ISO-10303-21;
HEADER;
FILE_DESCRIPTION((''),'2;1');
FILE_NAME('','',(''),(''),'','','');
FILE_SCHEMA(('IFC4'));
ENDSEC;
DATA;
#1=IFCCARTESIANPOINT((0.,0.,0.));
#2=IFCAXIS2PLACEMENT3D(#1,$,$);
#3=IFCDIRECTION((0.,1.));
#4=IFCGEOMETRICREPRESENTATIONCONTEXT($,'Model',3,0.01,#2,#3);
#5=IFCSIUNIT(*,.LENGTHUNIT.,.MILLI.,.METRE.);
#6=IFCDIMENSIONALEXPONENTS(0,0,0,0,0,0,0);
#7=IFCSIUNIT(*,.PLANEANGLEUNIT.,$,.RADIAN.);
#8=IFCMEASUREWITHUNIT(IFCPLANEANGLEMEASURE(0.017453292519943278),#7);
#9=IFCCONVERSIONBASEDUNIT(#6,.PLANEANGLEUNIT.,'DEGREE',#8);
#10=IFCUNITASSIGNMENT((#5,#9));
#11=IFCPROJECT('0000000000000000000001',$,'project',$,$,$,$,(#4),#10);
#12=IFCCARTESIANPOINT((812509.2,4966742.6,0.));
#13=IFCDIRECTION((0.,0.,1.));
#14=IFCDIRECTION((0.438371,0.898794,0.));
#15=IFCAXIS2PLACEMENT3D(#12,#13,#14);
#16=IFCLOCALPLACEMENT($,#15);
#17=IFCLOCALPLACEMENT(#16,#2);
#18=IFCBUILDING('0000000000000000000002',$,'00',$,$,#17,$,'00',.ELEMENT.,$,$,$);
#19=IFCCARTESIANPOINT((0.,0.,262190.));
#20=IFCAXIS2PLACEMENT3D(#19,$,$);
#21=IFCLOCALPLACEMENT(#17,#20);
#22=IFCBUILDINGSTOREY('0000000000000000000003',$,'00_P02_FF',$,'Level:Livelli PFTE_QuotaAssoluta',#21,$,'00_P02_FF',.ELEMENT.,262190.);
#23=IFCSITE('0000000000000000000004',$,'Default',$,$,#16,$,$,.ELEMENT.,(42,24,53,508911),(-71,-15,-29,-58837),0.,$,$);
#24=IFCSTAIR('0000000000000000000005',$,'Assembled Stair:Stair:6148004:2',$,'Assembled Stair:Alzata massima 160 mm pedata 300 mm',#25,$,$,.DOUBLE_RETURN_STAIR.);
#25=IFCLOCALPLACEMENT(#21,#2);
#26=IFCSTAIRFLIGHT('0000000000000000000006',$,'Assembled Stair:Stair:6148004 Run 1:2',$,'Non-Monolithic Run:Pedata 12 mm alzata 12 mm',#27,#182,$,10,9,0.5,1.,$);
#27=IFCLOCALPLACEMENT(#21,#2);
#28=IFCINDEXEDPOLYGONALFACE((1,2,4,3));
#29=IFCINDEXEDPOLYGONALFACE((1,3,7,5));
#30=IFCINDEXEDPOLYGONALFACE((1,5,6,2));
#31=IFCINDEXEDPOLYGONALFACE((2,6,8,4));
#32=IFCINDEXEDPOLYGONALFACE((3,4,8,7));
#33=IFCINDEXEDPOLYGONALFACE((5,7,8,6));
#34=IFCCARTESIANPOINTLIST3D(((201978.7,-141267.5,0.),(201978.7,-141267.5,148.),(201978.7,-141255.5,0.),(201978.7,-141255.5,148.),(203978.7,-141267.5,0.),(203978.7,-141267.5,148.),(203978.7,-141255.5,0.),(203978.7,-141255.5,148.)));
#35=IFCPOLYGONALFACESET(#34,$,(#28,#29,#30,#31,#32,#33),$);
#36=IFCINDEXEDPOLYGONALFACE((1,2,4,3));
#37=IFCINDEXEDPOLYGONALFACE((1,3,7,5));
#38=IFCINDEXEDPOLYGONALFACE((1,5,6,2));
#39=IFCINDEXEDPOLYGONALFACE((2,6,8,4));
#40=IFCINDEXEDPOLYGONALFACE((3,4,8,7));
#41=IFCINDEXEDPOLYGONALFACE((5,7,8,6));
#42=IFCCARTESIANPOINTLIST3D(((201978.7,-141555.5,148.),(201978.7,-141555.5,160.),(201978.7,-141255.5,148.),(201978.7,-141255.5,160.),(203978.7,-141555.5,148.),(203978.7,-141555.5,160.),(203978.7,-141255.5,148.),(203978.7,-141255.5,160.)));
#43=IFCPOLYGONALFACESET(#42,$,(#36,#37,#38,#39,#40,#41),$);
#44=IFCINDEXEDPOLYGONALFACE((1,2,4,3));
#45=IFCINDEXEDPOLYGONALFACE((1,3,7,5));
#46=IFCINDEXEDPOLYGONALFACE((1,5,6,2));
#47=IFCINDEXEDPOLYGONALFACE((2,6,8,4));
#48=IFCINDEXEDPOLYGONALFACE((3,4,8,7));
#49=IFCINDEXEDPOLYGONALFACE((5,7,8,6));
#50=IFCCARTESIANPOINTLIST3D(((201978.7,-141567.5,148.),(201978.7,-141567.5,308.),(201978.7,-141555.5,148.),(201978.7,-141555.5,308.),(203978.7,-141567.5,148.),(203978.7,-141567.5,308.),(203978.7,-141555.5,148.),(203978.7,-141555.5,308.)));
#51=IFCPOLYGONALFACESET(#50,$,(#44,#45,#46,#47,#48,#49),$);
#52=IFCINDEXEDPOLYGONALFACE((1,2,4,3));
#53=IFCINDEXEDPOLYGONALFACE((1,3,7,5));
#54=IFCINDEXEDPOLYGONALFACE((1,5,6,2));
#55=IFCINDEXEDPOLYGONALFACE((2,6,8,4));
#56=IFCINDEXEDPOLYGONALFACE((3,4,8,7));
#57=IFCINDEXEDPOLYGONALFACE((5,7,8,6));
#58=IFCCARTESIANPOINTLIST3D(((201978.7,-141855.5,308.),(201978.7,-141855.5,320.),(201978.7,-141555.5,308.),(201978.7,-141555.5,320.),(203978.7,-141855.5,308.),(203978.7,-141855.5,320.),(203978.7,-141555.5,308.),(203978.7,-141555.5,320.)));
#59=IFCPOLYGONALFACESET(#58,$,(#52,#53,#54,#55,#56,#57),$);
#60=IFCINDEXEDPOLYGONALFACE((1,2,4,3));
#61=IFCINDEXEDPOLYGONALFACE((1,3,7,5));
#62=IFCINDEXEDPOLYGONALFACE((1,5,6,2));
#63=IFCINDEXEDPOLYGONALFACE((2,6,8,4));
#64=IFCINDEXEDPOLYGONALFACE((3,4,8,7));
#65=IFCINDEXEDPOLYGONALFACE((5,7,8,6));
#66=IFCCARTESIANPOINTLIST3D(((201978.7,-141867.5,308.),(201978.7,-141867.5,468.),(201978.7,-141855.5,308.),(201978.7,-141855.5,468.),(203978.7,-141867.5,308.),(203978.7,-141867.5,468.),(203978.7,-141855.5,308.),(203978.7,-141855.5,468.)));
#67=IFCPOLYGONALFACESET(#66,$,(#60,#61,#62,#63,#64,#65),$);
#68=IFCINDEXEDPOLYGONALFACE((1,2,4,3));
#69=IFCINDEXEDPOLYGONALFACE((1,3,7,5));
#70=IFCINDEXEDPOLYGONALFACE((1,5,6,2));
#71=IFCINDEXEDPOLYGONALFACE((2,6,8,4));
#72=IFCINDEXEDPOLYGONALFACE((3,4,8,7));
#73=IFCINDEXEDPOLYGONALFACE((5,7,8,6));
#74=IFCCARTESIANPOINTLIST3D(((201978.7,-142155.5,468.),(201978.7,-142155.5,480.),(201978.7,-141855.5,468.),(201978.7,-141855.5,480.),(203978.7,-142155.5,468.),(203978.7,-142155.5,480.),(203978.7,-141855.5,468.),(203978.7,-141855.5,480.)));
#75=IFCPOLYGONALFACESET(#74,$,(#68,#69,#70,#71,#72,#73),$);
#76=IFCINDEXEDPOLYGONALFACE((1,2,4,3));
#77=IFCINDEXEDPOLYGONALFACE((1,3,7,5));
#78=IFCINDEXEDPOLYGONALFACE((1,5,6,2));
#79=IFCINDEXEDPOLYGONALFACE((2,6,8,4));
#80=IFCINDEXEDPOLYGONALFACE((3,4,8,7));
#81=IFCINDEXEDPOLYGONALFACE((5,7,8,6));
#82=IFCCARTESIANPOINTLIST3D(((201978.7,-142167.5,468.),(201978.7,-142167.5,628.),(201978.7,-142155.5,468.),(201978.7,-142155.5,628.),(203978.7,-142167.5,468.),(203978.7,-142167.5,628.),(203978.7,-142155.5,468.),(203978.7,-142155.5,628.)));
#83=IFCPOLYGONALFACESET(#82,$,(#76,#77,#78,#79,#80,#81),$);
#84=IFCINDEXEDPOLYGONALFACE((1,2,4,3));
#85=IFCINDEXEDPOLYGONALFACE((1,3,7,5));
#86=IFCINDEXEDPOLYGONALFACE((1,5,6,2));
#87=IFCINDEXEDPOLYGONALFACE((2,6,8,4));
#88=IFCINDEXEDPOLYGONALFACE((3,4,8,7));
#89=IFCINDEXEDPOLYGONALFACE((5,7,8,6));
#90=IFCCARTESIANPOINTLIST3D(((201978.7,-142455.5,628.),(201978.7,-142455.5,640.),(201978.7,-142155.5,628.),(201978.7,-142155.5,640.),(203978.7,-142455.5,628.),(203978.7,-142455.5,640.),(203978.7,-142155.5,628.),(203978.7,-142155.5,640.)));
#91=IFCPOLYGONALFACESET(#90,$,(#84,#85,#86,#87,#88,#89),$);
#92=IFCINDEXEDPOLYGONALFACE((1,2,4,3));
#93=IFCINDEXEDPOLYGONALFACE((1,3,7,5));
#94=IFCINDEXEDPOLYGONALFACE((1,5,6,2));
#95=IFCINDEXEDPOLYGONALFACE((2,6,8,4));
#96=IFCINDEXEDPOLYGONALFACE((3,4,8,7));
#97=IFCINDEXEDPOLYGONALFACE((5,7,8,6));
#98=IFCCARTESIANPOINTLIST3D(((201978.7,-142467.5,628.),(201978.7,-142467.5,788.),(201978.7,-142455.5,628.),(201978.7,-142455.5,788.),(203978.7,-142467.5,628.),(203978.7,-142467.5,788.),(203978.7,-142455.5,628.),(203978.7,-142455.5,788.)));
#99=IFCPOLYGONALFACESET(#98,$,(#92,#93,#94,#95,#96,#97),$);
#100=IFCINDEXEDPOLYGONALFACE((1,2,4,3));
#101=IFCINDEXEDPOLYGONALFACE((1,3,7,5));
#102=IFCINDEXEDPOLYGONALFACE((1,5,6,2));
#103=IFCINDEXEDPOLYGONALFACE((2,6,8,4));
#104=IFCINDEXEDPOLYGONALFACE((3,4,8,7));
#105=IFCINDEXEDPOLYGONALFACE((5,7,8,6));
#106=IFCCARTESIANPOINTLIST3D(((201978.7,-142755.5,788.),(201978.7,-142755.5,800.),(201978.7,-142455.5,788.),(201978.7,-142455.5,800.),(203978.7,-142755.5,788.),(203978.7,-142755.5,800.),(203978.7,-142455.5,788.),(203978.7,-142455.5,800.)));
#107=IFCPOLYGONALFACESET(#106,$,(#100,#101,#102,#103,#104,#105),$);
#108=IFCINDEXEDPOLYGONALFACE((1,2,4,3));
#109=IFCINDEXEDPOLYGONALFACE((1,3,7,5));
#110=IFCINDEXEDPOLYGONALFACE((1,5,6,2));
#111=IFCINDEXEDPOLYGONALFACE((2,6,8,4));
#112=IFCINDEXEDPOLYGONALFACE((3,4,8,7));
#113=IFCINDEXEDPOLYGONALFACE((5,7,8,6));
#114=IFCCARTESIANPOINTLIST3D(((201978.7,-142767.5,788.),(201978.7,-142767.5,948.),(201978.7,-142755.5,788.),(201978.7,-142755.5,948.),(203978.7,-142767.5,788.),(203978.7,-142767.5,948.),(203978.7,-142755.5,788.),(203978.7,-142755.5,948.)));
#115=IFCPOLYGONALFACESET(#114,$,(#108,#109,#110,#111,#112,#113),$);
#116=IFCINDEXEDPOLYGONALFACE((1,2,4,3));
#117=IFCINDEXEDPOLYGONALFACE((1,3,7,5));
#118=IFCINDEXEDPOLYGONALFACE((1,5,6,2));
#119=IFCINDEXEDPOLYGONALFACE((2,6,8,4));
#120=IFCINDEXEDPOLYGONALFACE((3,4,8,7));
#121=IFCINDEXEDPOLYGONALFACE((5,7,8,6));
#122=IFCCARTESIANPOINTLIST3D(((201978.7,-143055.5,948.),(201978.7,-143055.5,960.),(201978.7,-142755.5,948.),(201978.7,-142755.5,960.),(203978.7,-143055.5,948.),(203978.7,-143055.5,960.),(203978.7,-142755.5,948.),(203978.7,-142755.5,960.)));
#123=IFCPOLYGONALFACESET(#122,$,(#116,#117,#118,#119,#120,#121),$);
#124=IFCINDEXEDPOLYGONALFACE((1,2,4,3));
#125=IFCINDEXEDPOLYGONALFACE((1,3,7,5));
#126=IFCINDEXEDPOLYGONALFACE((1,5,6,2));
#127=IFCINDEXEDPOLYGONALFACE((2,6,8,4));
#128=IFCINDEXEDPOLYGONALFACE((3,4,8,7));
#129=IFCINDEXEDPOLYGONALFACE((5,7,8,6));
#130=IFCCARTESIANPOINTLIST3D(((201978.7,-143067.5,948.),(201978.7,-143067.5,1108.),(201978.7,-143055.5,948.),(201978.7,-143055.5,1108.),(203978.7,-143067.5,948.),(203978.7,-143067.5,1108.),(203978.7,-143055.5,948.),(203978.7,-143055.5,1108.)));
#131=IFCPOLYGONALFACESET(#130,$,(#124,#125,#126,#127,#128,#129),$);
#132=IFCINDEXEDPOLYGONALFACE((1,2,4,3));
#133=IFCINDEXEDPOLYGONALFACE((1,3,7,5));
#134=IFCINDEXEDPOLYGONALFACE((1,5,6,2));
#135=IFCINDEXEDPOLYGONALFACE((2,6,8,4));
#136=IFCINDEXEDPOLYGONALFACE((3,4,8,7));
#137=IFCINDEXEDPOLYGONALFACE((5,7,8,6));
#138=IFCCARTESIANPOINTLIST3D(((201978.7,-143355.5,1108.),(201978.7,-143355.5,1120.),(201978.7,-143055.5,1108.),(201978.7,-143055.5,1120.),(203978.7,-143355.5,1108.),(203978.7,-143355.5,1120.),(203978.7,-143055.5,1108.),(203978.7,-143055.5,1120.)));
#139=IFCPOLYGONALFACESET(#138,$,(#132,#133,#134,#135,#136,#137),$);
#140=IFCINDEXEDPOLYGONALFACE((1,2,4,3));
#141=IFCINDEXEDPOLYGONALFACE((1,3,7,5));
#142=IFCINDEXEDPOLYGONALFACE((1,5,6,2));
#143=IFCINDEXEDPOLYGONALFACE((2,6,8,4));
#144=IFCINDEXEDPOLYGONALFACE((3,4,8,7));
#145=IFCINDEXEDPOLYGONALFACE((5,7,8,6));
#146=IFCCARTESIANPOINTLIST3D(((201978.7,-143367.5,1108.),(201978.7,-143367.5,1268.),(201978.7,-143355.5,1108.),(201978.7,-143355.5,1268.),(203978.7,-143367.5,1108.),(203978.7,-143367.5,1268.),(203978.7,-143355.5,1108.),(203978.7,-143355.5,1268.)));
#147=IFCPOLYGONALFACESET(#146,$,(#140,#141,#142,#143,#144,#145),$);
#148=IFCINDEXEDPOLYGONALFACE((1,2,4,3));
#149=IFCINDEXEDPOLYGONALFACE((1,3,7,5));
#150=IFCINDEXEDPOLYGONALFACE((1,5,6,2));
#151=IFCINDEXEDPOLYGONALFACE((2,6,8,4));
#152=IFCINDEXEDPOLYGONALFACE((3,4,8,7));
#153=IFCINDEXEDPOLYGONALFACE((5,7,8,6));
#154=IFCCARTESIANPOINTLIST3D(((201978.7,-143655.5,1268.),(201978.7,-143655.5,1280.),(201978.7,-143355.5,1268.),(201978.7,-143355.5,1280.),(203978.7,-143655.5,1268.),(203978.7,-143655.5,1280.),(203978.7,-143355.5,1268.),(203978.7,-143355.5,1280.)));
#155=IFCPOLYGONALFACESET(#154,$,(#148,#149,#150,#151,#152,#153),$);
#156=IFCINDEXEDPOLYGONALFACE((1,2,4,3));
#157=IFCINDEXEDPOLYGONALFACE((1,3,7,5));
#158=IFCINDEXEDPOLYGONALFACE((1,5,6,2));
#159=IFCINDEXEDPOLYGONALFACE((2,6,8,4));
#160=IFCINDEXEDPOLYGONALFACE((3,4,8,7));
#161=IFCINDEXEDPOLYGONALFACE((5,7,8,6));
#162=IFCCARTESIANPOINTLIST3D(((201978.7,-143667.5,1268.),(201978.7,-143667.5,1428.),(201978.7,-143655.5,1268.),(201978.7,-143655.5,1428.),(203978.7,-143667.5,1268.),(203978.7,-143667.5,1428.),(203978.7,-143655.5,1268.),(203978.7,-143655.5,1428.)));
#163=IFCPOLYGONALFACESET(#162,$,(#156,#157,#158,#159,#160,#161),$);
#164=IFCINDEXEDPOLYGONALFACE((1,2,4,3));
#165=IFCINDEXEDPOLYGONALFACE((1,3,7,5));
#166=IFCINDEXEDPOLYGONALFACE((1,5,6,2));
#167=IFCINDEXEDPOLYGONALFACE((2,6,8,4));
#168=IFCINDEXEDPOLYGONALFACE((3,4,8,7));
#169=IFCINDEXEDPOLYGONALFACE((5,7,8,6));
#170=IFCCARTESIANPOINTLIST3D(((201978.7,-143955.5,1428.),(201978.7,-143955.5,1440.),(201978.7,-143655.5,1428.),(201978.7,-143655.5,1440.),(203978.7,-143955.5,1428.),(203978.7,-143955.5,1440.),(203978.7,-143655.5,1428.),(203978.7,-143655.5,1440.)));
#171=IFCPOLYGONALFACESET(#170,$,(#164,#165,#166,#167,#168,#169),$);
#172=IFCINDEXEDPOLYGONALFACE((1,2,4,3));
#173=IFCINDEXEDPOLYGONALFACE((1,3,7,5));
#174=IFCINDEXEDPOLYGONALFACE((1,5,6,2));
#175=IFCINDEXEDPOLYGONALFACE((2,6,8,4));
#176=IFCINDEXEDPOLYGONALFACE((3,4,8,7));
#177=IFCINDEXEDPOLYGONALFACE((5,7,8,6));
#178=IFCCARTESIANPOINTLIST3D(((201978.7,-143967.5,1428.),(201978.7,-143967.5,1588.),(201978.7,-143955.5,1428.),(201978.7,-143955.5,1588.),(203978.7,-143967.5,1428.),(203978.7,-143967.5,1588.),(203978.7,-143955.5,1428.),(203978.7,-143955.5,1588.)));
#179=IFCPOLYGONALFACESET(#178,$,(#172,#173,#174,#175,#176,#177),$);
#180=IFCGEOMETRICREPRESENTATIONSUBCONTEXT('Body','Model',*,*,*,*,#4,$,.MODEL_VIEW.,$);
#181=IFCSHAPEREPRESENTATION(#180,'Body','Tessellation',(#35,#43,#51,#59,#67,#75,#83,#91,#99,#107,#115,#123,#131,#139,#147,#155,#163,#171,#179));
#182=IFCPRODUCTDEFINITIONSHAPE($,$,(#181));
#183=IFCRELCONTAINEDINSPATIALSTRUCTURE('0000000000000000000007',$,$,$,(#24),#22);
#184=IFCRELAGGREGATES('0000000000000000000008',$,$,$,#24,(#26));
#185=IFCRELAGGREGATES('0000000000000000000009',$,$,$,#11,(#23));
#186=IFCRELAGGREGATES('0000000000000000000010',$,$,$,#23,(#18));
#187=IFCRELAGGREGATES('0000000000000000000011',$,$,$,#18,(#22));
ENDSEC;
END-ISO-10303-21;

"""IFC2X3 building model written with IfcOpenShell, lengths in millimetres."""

from ifc_helpers import new_model, entity, si_unit, converted_unit, direction, frame, frame_2d, origin, origin_2d_with_axis, place, context, subcontext, project, spatial, rectangle, extrude, element, aggregate, save


model = new_model("IFC2X3")

# Units and contexts
model_context = context("Model", 3, precision=0.01, world=origin(), true_north=direction((0.0, 1.0)))
body_context = subcontext(model_context, "Body", "Model", "MODEL_VIEW")
ifc_project = project(units=[si_unit("LENGTHUNIT", "METRE", prefix="MILLI"), converted_unit("PLANEANGLEUNIT", "DEGREE", entity("IfcPlaneAngleMeasure", 0.017453292519943278), si_unit("PLANEANGLEUNIT", "RADIAN"), dimensions=[0, 0, 0, 0, 0, 0, 0])], contexts=[model_context])

# Site, building, storey
site_placement = place(None, frame((812509.2, 4966742.6, 0.0), z_axis=(0.0, 0.0, 1.0), x_axis=(0.438371, 0.898794, 0.0)))
site = spatial("IfcSite", under=ifc_project, at=site_placement, Name="Default", CompositionType="ELEMENT", RefLatitude=(42, 24, 53, 508911), RefLongitude=(-71, -15, -29, -58837), RefElevation=0.0)
building_placement = place(site_placement, origin())
building = spatial("IfcBuilding", under=site, at=building_placement, Name="00", LongName="00", CompositionType="ELEMENT")
storey_placement = place(building_placement, frame((0.0, 0.0, 262190.0)))
storey = spatial("IfcBuildingStorey", under=building, at=storey_placement, Name="00_P02_FF", ObjectType="Level:Livelli PFTE_QuotaAssoluta", LongName="00_P02_FF", CompositionType="ELEMENT", Elevation=262190.0)

# Stair
stair_1_placement = place(storey_placement, origin())
stair_1 = element("IfcStair", 1, at=stair_1_placement, inside=storey, Name="Assembled Stair:Stair:6148004:2", ObjectType="Assembled Stair:Alzata massima 160 mm pedata 300 mm", ShapeType="DOUBLE_RETURN_STAIR")

# Stair flight
stair_flight_1_placement = place(stair_1_placement, origin())
stair_flight_1 = element("IfcStairFlight", 2, at=stair_flight_1_placement, Name="Assembled Stair:Stair:6148004 Run 1:2", ObjectType="Non-Monolithic Run:Pedata 12 mm alzata 12 mm", NumberOfRiser=10, NumberOfTreads=9, RiserHeight=0.5, TreadLength=1.0, context=body_context, shape_type="SweptSolid", body=[
    extrude(rectangle(XDim=2000.0, YDim=12.0, at=origin_2d_with_axis()), frame((202978.7, -141261.5, 0.0)), (0.0, 0.0, 1.0), 148.0),
    extrude(rectangle(XDim=300.0, YDim=2000.0, at=frame_2d((0.0, 0.0), x_axis=(1.0, 0.0))), frame((202978.7, -141405.5, 148.0), z_axis=(0.0, 0.0, 1.0), x_axis=(0.0, 1.0, 0.0)), (0.0, 0.0, 1.0), 12.0),
    extrude(rectangle(XDim=2000.0, YDim=12.0, at=origin_2d_with_axis()), frame((202978.7, -141561.5, 148.0)), (0.0, 0.0, 1.0), 160.0),
    extrude(rectangle(XDim=300.0, YDim=2000.0, at=origin_2d_with_axis()), frame((202978.7, -141705.5, 308.0), z_axis=(0.0, 0.0, 1.0), x_axis=(0.0, 1.0, 0.0)), (0.0, 0.0, 1.0), 12.0),
    extrude(rectangle(XDim=2000.0, YDim=12.0, at=origin_2d_with_axis()), frame((202978.7, -141861.5, 308.0)), (0.0, 0.0, 1.0), 160.0),
    extrude(rectangle(XDim=300.0, YDim=2000.0, at=origin_2d_with_axis()), frame((202978.7, -142005.5, 468.0), z_axis=(0.0, 0.0, 1.0), x_axis=(0.0, 1.0, 0.0)), (0.0, 0.0, 1.0), 12.0),
    extrude(rectangle(XDim=2000.0, YDim=12.0, at=origin_2d_with_axis()), frame((202978.7, -142161.5, 468.0)), (0.0, 0.0, 1.0), 160.0),
    extrude(rectangle(XDim=300.0, YDim=2000.0, at=origin_2d_with_axis()), frame((202978.7, -142305.5, 628.0), z_axis=(0.0, 0.0, 1.0), x_axis=(0.0, 1.0, 0.0)), (0.0, 0.0, 1.0), 12.0),
    extrude(rectangle(XDim=2000.0, YDim=12.0, at=origin_2d_with_axis()), frame((202978.7, -142461.5, 628.0)), (0.0, 0.0, 1.0), 160.0),
    extrude(rectangle(XDim=300.0, YDim=2000.0, at=origin_2d_with_axis()), frame((202978.7, -142605.5, 788.0), z_axis=(0.0, 0.0, 1.0), x_axis=(0.0, 1.0, 0.0)), (0.0, 0.0, 1.0), 12.0),
    extrude(rectangle(XDim=2000.0, YDim=12.0, at=origin_2d_with_axis()), frame((202978.7, -142761.5, 788.0)), (0.0, 0.0, 1.0), 160.0),
    extrude(rectangle(XDim=300.0, YDim=2000.0, at=origin_2d_with_axis()), frame((202978.7, -142905.5, 948.0), z_axis=(0.0, 0.0, 1.0), x_axis=(0.0, 1.0, 0.0)), (0.0, 0.0, 1.0), 12.0),
    extrude(rectangle(XDim=2000.0, YDim=12.0, at=origin_2d_with_axis()), frame((202978.7, -143061.5, 948.0)), (0.0, 0.0, 1.0), 160.0),
    extrude(rectangle(XDim=300.0, YDim=2000.0, at=origin_2d_with_axis()), frame((202978.7, -143205.5, 1108.0), z_axis=(0.0, 0.0, 1.0), x_axis=(0.0, 1.0, 0.0)), (0.0, 0.0, 1.0), 12.0),
    extrude(rectangle(XDim=2000.0, YDim=12.0, at=origin_2d_with_axis()), frame((202978.7, -143361.5, 1108.0)), (0.0, 0.0, 1.0), 160.0),
    extrude(rectangle(XDim=300.0, YDim=2000.0, at=origin_2d_with_axis()), frame((202978.7, -143505.5, 1268.0), z_axis=(0.0, 0.0, 1.0), x_axis=(0.0, 1.0, 0.0)), (0.0, 0.0, 1.0), 12.0),
    extrude(rectangle(XDim=2000.0, YDim=12.0, at=origin_2d_with_axis()), frame((202978.7, -143661.5, 1268.0)), (0.0, 0.0, 1.0), 160.0),
    extrude(rectangle(XDim=300.0, YDim=2000.0, at=origin_2d_with_axis()), frame((202978.7, -143805.5, 1428.0), z_axis=(0.0, 0.0, 1.0), x_axis=(0.0, 1.0, 0.0)), (0.0, 0.0, 1.0), 12.0),
    extrude(rectangle(XDim=2000.0, YDim=12.0, at=origin_2d_with_axis()), frame((202978.7, -143961.5, 1428.0)), (0.0, 0.0, 1.0), 160.0),
])
aggregate(stair_1, [stair_flight_1])

save(model, "model.ifc")
